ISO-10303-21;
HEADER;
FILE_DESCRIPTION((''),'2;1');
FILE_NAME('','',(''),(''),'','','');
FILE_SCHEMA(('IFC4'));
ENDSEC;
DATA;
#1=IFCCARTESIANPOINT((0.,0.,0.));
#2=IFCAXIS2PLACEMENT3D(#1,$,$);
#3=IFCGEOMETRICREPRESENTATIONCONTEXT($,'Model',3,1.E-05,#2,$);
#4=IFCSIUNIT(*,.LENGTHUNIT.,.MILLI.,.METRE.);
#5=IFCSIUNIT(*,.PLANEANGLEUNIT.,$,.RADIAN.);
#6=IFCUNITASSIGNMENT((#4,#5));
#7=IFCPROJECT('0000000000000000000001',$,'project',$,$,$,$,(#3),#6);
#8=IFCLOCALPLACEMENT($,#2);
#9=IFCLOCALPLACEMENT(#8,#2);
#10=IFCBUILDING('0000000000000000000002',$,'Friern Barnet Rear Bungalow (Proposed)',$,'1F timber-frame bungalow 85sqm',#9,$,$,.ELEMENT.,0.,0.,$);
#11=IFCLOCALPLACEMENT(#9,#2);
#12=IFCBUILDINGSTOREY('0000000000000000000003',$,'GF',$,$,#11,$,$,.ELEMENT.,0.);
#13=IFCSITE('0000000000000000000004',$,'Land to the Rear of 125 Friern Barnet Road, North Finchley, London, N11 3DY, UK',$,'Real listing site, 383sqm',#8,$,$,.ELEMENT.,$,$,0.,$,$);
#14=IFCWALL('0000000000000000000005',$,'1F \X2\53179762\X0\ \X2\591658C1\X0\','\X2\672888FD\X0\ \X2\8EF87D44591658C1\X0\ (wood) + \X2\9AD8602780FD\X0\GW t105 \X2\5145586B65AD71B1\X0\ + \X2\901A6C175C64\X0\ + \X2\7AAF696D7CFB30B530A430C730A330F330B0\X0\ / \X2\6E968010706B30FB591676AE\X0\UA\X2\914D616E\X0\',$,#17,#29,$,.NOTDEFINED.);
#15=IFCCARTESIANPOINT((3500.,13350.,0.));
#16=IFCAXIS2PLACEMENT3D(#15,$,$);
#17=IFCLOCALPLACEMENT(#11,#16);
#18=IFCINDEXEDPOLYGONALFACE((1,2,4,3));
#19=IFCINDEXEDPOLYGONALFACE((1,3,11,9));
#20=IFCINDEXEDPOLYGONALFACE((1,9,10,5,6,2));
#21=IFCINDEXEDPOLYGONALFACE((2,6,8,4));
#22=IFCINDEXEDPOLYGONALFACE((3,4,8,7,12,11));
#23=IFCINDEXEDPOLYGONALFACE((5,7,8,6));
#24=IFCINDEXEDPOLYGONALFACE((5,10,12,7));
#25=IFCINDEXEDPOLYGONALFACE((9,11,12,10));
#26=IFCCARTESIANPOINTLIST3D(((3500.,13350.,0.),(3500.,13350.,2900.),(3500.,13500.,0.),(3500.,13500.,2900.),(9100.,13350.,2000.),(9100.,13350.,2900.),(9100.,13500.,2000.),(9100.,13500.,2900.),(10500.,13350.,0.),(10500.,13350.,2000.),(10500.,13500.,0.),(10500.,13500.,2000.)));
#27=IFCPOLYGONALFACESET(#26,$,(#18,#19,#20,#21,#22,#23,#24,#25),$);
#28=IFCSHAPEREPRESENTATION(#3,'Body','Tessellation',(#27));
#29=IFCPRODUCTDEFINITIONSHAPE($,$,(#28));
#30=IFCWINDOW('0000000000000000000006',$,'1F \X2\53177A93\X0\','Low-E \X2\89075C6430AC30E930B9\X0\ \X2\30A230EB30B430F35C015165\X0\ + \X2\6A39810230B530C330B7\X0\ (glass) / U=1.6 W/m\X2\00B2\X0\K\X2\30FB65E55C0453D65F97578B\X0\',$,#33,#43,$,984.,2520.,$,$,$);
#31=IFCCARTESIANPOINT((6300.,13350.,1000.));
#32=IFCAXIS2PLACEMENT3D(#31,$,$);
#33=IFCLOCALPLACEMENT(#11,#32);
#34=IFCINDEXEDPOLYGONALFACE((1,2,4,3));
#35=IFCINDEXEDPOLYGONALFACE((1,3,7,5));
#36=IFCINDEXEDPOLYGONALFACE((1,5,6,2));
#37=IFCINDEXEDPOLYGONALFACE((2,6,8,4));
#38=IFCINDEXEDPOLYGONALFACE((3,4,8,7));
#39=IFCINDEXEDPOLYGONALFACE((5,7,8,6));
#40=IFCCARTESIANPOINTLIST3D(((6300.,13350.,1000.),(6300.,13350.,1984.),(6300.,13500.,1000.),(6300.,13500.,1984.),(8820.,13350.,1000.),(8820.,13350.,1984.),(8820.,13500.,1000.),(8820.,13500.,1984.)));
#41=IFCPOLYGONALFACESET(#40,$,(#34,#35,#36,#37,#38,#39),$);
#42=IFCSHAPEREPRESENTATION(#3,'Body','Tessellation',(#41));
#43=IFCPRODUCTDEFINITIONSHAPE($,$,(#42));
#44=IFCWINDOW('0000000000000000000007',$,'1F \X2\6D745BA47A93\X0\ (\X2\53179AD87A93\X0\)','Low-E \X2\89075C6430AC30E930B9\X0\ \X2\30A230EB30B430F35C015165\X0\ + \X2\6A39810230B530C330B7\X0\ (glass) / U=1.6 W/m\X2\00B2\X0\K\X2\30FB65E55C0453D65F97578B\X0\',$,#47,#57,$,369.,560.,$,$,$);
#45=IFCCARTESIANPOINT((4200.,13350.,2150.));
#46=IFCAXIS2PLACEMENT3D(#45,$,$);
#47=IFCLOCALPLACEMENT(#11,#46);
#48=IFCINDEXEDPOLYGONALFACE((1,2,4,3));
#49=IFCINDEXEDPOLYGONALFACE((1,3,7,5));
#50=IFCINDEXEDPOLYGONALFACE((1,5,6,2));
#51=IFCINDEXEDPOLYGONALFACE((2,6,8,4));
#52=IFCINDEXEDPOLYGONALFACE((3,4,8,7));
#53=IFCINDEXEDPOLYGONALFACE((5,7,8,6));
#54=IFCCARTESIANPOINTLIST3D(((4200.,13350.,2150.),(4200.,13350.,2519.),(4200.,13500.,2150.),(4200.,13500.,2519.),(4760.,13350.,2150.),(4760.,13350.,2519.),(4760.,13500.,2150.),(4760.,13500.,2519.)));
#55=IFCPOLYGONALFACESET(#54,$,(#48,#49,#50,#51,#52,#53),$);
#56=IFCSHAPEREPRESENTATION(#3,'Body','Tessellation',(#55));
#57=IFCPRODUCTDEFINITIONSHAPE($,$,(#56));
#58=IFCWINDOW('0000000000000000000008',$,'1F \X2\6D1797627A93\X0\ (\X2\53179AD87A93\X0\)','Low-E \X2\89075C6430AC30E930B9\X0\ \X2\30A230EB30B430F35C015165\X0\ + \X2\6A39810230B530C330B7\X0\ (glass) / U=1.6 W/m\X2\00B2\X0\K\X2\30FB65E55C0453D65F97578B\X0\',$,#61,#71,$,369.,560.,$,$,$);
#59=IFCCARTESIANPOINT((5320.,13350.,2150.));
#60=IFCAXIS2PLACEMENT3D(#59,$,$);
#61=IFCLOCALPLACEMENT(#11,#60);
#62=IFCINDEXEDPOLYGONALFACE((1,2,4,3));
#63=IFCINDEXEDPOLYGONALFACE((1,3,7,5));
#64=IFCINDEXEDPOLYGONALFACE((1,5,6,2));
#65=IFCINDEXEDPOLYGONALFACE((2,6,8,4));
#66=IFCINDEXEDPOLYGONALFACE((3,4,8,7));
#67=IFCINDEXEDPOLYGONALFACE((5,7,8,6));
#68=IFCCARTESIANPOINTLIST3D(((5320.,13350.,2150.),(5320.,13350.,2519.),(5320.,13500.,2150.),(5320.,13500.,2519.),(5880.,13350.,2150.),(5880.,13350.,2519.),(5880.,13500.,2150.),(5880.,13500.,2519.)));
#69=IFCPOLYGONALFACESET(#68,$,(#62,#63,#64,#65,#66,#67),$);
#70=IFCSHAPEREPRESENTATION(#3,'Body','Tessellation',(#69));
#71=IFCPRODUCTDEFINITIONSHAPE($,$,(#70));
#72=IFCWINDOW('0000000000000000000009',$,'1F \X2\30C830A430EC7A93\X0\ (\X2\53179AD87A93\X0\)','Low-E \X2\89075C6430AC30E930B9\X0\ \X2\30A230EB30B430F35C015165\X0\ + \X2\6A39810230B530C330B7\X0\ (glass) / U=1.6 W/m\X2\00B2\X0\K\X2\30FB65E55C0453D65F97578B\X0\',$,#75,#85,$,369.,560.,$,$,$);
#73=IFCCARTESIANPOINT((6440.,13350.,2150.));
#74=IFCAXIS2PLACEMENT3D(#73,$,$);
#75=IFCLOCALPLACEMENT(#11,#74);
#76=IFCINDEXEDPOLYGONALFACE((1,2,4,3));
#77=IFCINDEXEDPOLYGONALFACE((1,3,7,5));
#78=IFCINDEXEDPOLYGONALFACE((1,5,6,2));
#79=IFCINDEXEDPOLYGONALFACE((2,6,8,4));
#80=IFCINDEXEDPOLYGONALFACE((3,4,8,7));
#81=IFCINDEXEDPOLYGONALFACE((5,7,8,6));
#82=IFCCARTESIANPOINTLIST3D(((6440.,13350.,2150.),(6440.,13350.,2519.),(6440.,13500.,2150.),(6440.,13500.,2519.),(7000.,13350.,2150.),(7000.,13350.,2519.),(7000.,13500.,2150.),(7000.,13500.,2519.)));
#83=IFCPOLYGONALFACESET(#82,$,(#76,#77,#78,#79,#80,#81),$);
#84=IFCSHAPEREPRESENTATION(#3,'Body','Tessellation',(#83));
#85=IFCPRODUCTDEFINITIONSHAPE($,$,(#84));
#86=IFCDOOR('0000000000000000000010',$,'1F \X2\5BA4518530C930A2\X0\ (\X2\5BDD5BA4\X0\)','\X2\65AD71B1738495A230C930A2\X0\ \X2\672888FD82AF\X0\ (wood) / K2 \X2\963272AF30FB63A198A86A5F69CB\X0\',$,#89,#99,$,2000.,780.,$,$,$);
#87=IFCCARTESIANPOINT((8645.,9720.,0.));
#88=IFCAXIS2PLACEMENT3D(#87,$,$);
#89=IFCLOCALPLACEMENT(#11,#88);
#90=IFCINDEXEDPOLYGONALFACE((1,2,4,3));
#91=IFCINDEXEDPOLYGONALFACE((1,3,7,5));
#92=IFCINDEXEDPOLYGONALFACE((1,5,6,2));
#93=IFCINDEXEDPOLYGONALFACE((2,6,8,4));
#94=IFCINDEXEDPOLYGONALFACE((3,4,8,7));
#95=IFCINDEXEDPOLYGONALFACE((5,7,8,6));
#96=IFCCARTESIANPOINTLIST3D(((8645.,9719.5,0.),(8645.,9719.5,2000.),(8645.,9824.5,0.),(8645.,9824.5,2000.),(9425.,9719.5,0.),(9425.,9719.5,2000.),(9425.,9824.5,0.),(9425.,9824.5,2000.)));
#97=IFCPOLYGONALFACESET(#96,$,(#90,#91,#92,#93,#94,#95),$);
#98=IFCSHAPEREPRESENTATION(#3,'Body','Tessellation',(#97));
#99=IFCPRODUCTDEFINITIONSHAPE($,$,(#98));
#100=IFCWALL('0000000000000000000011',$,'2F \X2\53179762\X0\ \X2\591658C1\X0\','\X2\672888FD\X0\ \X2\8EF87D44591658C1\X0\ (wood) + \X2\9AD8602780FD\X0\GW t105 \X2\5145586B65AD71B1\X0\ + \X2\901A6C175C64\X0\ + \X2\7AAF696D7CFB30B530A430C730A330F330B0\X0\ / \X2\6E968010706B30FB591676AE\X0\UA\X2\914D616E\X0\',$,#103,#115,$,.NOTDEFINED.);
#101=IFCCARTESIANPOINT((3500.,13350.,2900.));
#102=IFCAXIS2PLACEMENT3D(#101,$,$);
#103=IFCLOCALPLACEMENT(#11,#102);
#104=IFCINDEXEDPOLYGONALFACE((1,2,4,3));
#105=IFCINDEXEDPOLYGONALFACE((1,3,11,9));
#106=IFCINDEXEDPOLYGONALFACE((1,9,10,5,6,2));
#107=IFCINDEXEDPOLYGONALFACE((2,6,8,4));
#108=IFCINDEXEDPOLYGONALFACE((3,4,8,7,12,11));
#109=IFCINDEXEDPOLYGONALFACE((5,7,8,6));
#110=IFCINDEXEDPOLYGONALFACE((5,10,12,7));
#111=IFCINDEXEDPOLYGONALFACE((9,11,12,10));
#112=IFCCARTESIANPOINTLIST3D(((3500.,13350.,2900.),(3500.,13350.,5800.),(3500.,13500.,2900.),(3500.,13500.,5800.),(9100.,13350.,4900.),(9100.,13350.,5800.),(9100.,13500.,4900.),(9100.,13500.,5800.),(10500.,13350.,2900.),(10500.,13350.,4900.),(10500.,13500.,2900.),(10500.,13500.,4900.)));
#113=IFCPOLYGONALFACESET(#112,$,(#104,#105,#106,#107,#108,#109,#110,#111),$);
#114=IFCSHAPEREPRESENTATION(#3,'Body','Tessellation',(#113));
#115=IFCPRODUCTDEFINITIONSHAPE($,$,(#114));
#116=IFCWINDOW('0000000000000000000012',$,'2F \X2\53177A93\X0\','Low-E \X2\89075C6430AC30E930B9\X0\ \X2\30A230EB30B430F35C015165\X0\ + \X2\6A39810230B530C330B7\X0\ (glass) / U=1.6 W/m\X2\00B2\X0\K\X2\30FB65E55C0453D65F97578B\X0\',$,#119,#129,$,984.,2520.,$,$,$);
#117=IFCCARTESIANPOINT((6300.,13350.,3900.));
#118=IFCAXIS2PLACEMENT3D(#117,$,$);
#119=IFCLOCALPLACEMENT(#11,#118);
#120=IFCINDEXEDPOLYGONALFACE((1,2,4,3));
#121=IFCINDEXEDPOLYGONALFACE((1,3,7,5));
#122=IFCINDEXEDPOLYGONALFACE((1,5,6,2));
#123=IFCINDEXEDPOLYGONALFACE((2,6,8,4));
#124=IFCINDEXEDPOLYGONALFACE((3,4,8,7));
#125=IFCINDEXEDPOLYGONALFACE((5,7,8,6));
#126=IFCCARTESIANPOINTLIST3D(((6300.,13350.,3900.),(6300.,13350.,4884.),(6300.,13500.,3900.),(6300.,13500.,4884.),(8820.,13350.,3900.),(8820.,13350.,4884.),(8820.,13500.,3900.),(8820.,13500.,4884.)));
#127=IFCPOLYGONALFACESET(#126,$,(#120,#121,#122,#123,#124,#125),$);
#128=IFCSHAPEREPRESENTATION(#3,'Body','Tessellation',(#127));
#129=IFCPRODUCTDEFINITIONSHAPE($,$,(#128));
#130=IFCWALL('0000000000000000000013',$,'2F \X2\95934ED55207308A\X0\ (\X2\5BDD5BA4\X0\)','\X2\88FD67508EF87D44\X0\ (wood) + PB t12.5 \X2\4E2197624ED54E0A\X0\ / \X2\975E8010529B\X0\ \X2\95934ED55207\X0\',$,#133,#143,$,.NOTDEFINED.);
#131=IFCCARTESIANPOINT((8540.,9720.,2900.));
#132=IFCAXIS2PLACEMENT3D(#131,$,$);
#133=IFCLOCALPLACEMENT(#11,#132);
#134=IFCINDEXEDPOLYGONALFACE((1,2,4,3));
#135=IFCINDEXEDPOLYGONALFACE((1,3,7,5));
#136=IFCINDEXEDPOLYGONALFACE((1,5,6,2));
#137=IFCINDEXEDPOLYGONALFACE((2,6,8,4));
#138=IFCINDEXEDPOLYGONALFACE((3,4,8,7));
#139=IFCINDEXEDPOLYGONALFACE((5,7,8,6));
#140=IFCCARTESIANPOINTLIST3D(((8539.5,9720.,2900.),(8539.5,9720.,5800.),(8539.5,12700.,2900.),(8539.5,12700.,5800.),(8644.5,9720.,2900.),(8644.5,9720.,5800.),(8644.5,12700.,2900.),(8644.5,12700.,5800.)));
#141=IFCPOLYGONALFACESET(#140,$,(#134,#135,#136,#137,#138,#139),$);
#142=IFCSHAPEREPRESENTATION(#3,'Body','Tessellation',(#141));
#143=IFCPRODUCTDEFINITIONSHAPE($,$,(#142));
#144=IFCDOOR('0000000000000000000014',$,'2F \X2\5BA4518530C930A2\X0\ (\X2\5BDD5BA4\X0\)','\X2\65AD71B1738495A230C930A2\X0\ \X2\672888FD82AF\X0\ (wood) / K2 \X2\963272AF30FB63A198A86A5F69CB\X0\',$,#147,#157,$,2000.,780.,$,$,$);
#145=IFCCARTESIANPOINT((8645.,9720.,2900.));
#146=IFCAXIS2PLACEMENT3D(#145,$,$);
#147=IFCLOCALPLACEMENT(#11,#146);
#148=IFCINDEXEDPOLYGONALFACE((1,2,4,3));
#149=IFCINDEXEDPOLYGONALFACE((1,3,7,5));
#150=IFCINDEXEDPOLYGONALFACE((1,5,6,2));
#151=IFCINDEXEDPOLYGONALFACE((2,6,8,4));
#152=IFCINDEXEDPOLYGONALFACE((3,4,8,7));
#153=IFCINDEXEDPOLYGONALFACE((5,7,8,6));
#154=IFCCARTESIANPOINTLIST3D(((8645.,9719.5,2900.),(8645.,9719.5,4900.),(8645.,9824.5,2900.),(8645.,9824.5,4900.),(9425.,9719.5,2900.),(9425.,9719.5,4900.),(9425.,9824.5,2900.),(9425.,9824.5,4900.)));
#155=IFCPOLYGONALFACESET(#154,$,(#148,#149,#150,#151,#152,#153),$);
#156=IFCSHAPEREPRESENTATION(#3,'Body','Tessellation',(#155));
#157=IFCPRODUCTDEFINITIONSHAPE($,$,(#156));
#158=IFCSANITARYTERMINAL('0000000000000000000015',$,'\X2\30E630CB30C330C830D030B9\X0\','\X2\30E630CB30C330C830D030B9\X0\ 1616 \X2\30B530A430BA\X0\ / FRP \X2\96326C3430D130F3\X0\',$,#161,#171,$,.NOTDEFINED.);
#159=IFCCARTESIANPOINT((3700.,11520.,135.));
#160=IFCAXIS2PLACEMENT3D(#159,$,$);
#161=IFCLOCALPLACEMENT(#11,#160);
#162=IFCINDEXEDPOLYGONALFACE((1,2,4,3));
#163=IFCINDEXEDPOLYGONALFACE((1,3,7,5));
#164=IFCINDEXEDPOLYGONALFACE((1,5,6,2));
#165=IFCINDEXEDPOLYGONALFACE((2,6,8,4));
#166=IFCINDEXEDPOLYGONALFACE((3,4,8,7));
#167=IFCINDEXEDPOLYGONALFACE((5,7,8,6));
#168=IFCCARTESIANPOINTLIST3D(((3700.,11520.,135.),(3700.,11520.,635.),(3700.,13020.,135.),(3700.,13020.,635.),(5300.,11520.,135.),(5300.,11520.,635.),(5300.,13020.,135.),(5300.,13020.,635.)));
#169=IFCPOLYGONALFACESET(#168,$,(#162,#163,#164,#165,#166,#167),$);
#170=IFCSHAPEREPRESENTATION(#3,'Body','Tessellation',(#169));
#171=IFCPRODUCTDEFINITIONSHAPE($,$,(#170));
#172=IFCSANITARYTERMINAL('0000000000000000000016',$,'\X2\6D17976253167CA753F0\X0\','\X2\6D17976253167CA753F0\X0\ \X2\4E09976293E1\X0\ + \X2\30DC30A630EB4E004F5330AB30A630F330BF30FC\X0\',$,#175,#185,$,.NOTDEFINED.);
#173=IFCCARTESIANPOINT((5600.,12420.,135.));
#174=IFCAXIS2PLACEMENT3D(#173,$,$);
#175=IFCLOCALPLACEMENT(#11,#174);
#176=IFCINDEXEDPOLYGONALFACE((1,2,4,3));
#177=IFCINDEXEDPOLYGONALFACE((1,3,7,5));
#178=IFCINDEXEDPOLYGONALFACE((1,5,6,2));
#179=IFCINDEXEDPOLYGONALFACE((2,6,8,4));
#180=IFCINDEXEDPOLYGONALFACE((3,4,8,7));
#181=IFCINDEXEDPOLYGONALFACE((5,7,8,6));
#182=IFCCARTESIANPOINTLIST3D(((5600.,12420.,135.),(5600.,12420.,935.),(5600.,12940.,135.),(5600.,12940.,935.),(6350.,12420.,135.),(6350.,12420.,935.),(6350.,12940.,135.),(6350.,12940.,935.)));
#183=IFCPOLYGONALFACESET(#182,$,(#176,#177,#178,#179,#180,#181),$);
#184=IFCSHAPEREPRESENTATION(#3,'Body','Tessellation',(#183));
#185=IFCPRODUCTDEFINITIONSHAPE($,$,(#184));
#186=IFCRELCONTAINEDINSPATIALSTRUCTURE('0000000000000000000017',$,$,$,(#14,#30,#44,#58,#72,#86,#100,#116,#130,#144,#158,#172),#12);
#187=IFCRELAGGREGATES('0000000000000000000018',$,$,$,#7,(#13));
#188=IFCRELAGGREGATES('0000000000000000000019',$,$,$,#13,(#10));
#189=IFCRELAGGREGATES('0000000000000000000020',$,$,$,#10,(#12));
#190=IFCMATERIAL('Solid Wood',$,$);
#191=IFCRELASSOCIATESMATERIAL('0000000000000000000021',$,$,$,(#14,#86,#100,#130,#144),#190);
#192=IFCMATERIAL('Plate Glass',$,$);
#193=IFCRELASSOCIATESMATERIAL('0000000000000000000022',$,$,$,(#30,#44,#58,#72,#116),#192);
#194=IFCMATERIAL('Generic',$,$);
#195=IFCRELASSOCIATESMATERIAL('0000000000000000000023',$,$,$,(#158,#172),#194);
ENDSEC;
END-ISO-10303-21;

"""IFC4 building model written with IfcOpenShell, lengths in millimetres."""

from ifc_helpers import new_model, si_unit, frame, frame_2d, origin, place, context, project, spatial, rectangle, extrude, material, element, fill, save


model = new_model("IFC4")

# Units and contexts
model_context = context("Model", 3, precision=1e-05, world=origin())
ifc_project = project(units=[si_unit("LENGTHUNIT", "METRE", prefix="MILLI"), si_unit("PLANEANGLEUNIT", "RADIAN")], contexts=[model_context])

# Site, building, storey
site_placement = place(None, origin())
site = spatial("IfcSite", under=ifc_project, at=site_placement, Name="Land to the Rear of 125 Friern Barnet Road, North Finchley, London, N11 3DY, UK", ObjectType="Real listing site, 383sqm", CompositionType="ELEMENT", RefElevation=0.0)
building_placement = place(site_placement, origin())
building = spatial("IfcBuilding", under=site, at=building_placement, Name="Friern Barnet Rear Bungalow (Proposed)", ObjectType="1F timber-frame bungalow 85sqm", CompositionType="ELEMENT", ElevationOfRefHeight=0.0, ElevationOfTerrain=0.0)
storey_placement = place(building_placement, origin())
storey = spatial("IfcBuildingStorey", under=building, at=storey_placement, Name="GF", CompositionType="ELEMENT", Elevation=0.0)

# Wall, openings, windows
ifc_material_1 = material(Name="Solid Wood")
wall_1_placement = place(storey_placement, frame((3500.0, 13350.0, 0.0)))
wall_1 = element("IfcWall", 1, at=wall_1_placement, inside=storey, material=ifc_material_1, Name="1F 北面 外壁", Description="木製 軸組外壁 (wood) + 高性能GW t105 充填断熱 + 通気層 + 窯業系サイディング / 準耐火・外皮UA配慮", PredefinedType="NOTDEFINED", context=model_context, shape_type="SweptSolid", body=[
    extrude(rectangle(XDim=7000.0, YDim=150.0, at=frame_2d((3500.0, 75.0))), frame((3500.0, 13350.0, 0.0)), (0.0, 0.0, 1.0), 2900.0),
])
opening_1_placement = place(storey_placement, frame((6300.0, 13350.0, 1000.0)))
opening_1 = element("IfcOpeningElement", 2, at=opening_1_placement, cuts=wall_1, PredefinedType="NOTDEFINED", context=model_context, shape_type="SweptSolid", body=[
    extrude(rectangle(XDim=2520.0, YDim=150.0, at=frame_2d((1260.0, 75.0))), frame((6300.0, 13350.0, 1000.0)), (0.0, 0.0, 1.0), 984.0),
])
opening_2_placement = place(storey_placement, frame((4200.0, 13350.0, 2150.0)))
opening_2 = element("IfcOpeningElement", 3, at=opening_2_placement, cuts=wall_1, PredefinedType="NOTDEFINED", context=model_context, shape_type="SweptSolid", body=[
    extrude(rectangle(XDim=560.0, YDim=150.0, at=frame_2d((280.0, 75.0))), frame((4200.0, 13350.0, 2150.0)), (0.0, 0.0, 1.0), 369.0),
])
opening_3_placement = place(storey_placement, frame((5320.0, 13350.0, 2150.0)))
opening_3 = element("IfcOpeningElement", 4, at=opening_3_placement, cuts=wall_1, PredefinedType="NOTDEFINED", context=model_context, shape_type="SweptSolid", body=[
    extrude(rectangle(XDim=560.0, YDim=150.0, at=frame_2d((280.0, 75.0))), frame((5320.0, 13350.0, 2150.0)), (0.0, 0.0, 1.0), 369.0),
])
opening_4_placement = place(storey_placement, frame((6440.0, 13350.0, 2150.0)))
opening_4 = element("IfcOpeningElement", 5, at=opening_4_placement, cuts=wall_1, PredefinedType="NOTDEFINED", context=model_context, shape_type="SweptSolid", body=[
    extrude(rectangle(XDim=560.0, YDim=150.0, at=frame_2d((280.0, 75.0))), frame((6440.0, 13350.0, 2150.0)), (0.0, 0.0, 1.0), 369.0),
])
ifc_material_2 = material(Name="Plate Glass")
window_1_placement = place(storey_placement, frame((6300.0, 13350.0, 1000.0)))
window_1 = element("IfcWindow", 6, at=window_1_placement, inside=storey, material=ifc_material_2, Name="1F 北窓", Description="Low-E 複層ガラス アルゴン封入 + 樹脂サッシ (glass) / U=1.6 W/m²K・日射取得型", OverallHeight=984.0, OverallWidth=2520.0, context=model_context, shape_type="SweptSolid", body=[
    extrude(rectangle(XDim=2520.0, YDim=150.0, at=frame_2d((1260.0, 75.0))), frame((6300.0, 13350.0, 1000.0)), (0.0, 0.0, 1.0), 984.0),
])
fill(opening_1, window_1)
window_2_placement = place(storey_placement, frame((4200.0, 13350.0, 2150.0)))
window_2 = element("IfcWindow", 7, at=window_2_placement, inside=storey, material=ifc_material_2, Name="1F 浴室窓 (北高窓)", Description="Low-E 複層ガラス アルゴン封入 + 樹脂サッシ (glass) / U=1.6 W/m²K・日射取得型", OverallHeight=369.0, OverallWidth=560.0, context=model_context, shape_type="SweptSolid", body=[
    extrude(rectangle(XDim=560.0, YDim=150.0, at=frame_2d((280.0, 75.0))), frame((4200.0, 13350.0, 2150.0)), (0.0, 0.0, 1.0), 369.0),
])
fill(opening_2, window_2)
window_3_placement = place(storey_placement, frame((5320.0, 13350.0, 2150.0)))
window_3 = element("IfcWindow", 8, at=window_3_placement, inside=storey, material=ifc_material_2, Name="1F 洗面窓 (北高窓)", Description="Low-E 複層ガラス アルゴン封入 + 樹脂サッシ (glass) / U=1.6 W/m²K・日射取得型", OverallHeight=369.0, OverallWidth=560.0, context=model_context, shape_type="SweptSolid", body=[
    extrude(rectangle(XDim=560.0, YDim=150.0, at=frame_2d((280.0, 75.0))), frame((5320.0, 13350.0, 2150.0)), (0.0, 0.0, 1.0), 369.0),
])
fill(opening_3, window_3)
window_4_placement = place(storey_placement, frame((6440.0, 13350.0, 2150.0)))
window_4 = element("IfcWindow", 9, at=window_4_placement, inside=storey, material=ifc_material_2, Name="1F トイレ窓 (北高窓)", Description="Low-E 複層ガラス アルゴン封入 + 樹脂サッシ (glass) / U=1.6 W/m²K・日射取得型", OverallHeight=369.0, OverallWidth=560.0, context=model_context, shape_type="SweptSolid", body=[
    extrude(rectangle(XDim=560.0, YDim=150.0, at=frame_2d((280.0, 75.0))), frame((6440.0, 13350.0, 2150.0)), (0.0, 0.0, 1.0), 369.0),
])
fill(opening_4, window_4)

# Door
door_1_placement = place(storey_placement, frame((8645.0, 9720.0, 0.0)))
element("IfcDoor", 10, at=door_1_placement, inside=storey, material=ifc_material_1, Name="1F 室内ドア (寝室)", Description="断熱玄関ドア 木製芯 (wood) / K2 防犯・採風機構", OverallHeight=2000.0, OverallWidth=780.0, context=model_context, shape_type="SweptSolid", body=[
    extrude(rectangle(XDim=780.0, YDim=105.0, at=frame_2d((390.0, 52.0))), frame((8645.0, 9720.0, 0.0)), (0.0, 0.0, 1.0), 2000.0),
])

# Wall, opening, window
wall_2_placement = place(storey_placement, frame((3500.0, 13350.0, 2900.0)))
wall_2 = element("IfcWall", 11, at=wall_2_placement, inside=storey, material=ifc_material_1, Name="2F 北面 外壁", Description="木製 軸組外壁 (wood) + 高性能GW t105 充填断熱 + 通気層 + 窯業系サイディング / 準耐火・外皮UA配慮", PredefinedType="NOTDEFINED", context=model_context, shape_type="SweptSolid", body=[
    extrude(rectangle(XDim=7000.0, YDim=150.0, at=frame_2d((3500.0, 75.0))), frame((3500.0, 13350.0, 2900.0)), (0.0, 0.0, 1.0), 2900.0),
])
opening_5_placement = place(storey_placement, frame((6300.0, 13350.0, 3900.0)))
opening_5 = element("IfcOpeningElement", 12, at=opening_5_placement, cuts=wall_2, PredefinedType="NOTDEFINED", context=model_context, shape_type="SweptSolid", body=[
    extrude(rectangle(XDim=2520.0, YDim=150.0, at=frame_2d((1260.0, 75.0))), frame((6300.0, 13350.0, 3900.0)), (0.0, 0.0, 1.0), 984.0),
])
window_5_placement = place(storey_placement, frame((6300.0, 13350.0, 3900.0)))
window_5 = element("IfcWindow", 13, at=window_5_placement, inside=storey, material=ifc_material_2, Name="2F 北窓", Description="Low-E 複層ガラス アルゴン封入 + 樹脂サッシ (glass) / U=1.6 W/m²K・日射取得型", OverallHeight=984.0, OverallWidth=2520.0, context=model_context, shape_type="SweptSolid", body=[
    extrude(rectangle(XDim=2520.0, YDim=150.0, at=frame_2d((1260.0, 75.0))), frame((6300.0, 13350.0, 3900.0)), (0.0, 0.0, 1.0), 984.0),
])
fill(opening_5, window_5)

# Wall
wall_3_placement = place(storey_placement, frame((8540.0, 9720.0, 2900.0)))
element("IfcWall", 14, at=wall_3_placement, inside=storey, material=ifc_material_1, Name="2F 間仕切り (寝室)", Description="製材軸組 (wood) + PB t12.5 両面仕上 / 非耐力 間仕切", PredefinedType="NOTDEFINED", context=model_context, shape_type="SweptSolid", body=[
    extrude(rectangle(XDim=105.0, YDim=2980.0, at=frame_2d((52.0, 1490.0))), frame((8540.0, 9720.0, 2900.0)), (0.0, 0.0, 1.0), 2900.0),
])

# Door
door_2_placement = place(storey_placement, frame((8645.0, 9720.0, 2900.0)))
element("IfcDoor", 15, at=door_2_placement, inside=storey, material=ifc_material_1, Name="2F 室内ドア (寝室)", Description="断熱玄関ドア 木製芯 (wood) / K2 防犯・採風機構", OverallHeight=2000.0, OverallWidth=780.0, context=model_context, shape_type="SweptSolid", body=[
    extrude(rectangle(XDim=780.0, YDim=105.0, at=frame_2d((390.0, 52.0))), frame((8645.0, 9720.0, 2900.0)), (0.0, 0.0, 1.0), 2000.0),
])

# Sanitary terminals
ifc_material_3 = material(Name="Generic")
sanitary_terminal_1_placement = place(storey_placement, frame((3700.0, 11520.0, 135.0)))
element("IfcSanitaryTerminal", 16, at=sanitary_terminal_1_placement, inside=storey, material=ifc_material_3, Name="ユニットバス", Description="ユニットバス 1616 サイズ / FRP 防水パン", PredefinedType="NOTDEFINED", context=model_context, shape_type="SweptSolid", body=[
    extrude(rectangle(XDim=1600.0, YDim=1500.0, at=frame_2d((800.0, 750.0))), frame((3700.0, 11520.0, 135.0)), (0.0, 0.0, 1.0), 500.0),
])
sanitary_terminal_2_placement = place(storey_placement, frame((5600.0, 12420.0, 135.0)))
element("IfcSanitaryTerminal", 17, at=sanitary_terminal_2_placement, inside=storey, material=ifc_material_3, Name="洗面化粧台", Description="洗面化粧台 三面鏡 + ボウル一体カウンター", PredefinedType="NOTDEFINED", context=model_context, shape_type="SweptSolid", body=[
    extrude(rectangle(XDim=750.0, YDim=520.0, at=frame_2d((375.0, 260.0))), frame((5600.0, 12420.0, 135.0)), (0.0, 0.0, 1.0), 800.0),
])

save(model, "model.ifc")
